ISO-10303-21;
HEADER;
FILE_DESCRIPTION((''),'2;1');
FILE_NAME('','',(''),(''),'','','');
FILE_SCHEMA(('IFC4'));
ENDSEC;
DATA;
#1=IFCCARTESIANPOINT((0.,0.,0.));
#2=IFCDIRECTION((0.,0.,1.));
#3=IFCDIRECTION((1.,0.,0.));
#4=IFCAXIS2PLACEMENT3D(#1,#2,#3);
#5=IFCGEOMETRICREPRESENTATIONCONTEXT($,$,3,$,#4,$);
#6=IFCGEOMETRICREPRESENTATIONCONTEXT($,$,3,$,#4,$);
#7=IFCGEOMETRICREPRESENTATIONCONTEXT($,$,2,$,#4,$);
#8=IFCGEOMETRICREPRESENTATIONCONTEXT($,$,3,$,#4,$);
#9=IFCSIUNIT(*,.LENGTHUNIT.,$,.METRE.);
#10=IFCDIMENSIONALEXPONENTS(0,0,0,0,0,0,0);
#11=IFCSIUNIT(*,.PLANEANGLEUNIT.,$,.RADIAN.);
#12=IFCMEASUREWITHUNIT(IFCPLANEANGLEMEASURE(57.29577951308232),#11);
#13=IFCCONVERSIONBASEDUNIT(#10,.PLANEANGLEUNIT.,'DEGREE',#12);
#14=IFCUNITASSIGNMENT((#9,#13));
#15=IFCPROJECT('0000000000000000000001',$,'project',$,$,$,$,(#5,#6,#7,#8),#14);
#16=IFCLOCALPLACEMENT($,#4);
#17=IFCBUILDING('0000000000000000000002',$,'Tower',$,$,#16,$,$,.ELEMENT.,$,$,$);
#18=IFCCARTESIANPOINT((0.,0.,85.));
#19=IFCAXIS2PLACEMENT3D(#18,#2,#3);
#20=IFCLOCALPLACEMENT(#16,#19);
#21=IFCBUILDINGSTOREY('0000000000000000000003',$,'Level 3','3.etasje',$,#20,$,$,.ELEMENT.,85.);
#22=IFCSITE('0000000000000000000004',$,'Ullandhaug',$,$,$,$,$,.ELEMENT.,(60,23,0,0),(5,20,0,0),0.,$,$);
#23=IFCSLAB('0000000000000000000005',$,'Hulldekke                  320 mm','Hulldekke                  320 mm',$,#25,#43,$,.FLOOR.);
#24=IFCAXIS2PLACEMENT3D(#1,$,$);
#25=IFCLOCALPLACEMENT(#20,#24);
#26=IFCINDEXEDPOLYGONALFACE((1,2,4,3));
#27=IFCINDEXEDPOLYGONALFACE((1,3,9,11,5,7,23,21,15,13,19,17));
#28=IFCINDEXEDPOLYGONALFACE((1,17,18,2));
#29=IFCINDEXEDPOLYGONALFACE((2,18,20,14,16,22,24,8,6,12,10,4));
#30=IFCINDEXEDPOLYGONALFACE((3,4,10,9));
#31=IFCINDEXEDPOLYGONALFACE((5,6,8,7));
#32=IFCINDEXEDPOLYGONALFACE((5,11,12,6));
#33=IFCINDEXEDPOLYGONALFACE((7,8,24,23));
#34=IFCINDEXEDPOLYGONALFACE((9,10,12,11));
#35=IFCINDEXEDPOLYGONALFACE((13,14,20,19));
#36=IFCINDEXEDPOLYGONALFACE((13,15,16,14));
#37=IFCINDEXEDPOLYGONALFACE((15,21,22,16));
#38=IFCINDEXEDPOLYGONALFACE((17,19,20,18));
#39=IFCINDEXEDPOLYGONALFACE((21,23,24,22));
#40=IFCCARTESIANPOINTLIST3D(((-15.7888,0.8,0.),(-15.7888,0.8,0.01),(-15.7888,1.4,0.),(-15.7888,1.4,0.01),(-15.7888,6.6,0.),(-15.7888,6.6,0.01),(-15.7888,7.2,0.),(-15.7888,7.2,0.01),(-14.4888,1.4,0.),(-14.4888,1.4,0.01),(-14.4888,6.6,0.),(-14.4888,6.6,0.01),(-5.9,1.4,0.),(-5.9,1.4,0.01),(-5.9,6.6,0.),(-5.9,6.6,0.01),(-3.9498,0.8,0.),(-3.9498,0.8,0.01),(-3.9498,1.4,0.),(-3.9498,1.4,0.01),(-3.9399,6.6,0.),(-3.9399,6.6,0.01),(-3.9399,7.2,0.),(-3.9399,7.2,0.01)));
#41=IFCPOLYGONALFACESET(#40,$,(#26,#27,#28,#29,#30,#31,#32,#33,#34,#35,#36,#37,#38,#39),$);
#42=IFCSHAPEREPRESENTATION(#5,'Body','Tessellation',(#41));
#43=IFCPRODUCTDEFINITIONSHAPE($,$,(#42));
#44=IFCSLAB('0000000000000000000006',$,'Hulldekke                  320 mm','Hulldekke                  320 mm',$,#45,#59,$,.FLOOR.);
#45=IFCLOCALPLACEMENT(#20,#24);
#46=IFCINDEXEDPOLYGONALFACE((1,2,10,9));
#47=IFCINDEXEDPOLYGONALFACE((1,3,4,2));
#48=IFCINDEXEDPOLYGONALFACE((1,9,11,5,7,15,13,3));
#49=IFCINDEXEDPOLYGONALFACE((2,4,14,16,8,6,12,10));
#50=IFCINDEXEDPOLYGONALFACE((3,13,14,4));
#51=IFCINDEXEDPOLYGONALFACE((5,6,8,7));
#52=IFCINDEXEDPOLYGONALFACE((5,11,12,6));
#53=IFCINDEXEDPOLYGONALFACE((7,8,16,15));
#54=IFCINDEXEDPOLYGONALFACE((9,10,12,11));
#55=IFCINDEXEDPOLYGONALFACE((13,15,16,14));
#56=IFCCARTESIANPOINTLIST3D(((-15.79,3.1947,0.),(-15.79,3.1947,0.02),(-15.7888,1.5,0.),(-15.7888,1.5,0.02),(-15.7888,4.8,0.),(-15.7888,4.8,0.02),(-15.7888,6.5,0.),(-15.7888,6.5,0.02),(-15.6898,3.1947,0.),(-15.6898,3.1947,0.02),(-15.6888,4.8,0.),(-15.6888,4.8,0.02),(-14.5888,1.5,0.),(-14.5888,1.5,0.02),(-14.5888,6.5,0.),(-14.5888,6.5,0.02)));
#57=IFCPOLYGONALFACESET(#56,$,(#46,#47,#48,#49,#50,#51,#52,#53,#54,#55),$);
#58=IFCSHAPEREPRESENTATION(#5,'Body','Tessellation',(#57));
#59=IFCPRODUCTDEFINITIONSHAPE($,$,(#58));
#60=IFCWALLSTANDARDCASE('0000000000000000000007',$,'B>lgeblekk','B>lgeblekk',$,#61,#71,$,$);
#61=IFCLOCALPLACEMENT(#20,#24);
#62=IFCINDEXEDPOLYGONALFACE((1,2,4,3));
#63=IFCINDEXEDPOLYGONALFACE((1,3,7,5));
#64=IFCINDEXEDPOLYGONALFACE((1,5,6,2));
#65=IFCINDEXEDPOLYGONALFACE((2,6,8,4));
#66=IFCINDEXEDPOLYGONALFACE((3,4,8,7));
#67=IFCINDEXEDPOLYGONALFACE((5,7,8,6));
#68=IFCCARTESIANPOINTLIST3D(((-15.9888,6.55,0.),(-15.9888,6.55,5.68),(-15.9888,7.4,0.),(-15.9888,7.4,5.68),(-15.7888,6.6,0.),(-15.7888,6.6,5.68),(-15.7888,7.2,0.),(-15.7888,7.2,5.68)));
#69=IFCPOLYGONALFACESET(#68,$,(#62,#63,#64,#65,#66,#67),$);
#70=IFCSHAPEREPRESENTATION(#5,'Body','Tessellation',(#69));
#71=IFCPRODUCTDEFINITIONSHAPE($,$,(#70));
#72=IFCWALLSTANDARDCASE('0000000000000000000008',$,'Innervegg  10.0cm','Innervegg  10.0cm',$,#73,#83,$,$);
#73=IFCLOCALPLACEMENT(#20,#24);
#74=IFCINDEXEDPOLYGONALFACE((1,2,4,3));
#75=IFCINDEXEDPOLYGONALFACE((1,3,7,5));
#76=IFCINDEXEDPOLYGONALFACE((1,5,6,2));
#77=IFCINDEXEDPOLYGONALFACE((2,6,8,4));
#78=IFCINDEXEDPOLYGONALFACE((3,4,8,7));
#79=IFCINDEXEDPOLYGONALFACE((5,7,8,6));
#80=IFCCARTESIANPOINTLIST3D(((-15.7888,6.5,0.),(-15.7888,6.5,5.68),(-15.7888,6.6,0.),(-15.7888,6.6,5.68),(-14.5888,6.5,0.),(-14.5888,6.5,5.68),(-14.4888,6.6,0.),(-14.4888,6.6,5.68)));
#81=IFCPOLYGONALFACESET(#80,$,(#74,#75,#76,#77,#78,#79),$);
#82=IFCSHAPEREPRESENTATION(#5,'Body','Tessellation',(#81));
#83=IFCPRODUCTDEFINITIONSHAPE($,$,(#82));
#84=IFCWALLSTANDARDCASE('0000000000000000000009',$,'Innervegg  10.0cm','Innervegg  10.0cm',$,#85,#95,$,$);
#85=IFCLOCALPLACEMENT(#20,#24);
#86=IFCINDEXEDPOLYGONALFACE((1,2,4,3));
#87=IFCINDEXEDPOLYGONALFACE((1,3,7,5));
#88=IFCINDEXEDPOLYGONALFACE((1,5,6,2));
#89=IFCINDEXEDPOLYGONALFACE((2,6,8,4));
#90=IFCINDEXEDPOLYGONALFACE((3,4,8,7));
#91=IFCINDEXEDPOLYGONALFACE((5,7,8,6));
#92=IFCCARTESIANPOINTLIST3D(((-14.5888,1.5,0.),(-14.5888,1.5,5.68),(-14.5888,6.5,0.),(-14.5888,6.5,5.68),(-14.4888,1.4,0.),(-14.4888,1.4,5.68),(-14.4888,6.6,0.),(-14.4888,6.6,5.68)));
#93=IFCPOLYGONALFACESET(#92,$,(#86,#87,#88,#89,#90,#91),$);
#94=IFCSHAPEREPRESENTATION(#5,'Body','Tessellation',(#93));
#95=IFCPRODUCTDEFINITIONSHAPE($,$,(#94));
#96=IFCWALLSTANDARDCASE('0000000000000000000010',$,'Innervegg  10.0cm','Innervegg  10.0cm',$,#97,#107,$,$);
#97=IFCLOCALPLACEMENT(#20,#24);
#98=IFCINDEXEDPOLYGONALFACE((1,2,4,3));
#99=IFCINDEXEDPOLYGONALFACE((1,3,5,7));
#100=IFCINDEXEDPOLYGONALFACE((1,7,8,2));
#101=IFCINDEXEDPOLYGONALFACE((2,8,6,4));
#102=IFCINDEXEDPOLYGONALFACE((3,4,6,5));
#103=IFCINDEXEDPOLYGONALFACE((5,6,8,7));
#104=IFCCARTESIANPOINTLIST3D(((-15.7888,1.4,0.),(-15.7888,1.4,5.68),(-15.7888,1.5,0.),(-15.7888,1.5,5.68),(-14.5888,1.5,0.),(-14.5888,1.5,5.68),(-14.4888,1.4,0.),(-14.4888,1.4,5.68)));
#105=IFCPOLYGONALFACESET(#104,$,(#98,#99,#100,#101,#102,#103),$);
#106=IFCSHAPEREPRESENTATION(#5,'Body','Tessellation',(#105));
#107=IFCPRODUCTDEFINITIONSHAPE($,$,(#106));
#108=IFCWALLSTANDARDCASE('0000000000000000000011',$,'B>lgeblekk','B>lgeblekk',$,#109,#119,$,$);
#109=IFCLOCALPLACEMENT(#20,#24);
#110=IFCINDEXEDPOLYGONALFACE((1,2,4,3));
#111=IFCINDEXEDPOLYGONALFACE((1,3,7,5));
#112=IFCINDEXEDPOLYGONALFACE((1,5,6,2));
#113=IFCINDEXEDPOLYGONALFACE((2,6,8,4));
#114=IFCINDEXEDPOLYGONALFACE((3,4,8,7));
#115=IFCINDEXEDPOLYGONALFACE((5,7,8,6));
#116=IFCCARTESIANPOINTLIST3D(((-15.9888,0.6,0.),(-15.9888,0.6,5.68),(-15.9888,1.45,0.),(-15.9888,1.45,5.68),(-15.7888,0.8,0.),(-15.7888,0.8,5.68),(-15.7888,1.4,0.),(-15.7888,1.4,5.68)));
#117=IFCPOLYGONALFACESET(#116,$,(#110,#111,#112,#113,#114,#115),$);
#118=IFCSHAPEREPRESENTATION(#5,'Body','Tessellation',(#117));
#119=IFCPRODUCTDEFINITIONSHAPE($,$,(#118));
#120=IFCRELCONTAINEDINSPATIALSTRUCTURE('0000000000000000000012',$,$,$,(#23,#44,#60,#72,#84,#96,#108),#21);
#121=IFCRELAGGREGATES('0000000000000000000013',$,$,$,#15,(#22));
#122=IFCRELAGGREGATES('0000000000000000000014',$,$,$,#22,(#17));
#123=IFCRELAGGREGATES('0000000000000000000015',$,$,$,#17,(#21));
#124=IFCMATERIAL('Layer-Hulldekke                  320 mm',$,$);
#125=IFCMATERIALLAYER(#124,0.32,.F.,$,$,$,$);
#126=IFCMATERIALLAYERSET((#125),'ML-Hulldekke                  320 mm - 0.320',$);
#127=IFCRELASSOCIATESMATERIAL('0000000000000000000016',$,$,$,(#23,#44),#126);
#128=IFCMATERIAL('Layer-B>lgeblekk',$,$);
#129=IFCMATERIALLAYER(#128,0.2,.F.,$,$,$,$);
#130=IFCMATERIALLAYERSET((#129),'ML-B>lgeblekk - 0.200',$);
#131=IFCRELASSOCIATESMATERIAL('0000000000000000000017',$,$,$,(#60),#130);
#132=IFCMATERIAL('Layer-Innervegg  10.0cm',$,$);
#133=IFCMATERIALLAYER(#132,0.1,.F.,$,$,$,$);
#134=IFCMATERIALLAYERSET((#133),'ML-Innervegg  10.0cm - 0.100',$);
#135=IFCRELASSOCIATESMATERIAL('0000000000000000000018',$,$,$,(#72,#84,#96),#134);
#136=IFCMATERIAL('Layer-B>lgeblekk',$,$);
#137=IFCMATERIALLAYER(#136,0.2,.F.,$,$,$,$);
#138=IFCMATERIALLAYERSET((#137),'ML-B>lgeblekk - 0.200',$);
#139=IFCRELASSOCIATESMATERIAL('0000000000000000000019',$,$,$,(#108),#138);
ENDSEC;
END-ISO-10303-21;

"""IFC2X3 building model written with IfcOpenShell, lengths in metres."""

from ifc_helpers import new_model, entity, si_unit, converted_unit, frame, origin_with_axes, place, context, project, spatial, polyline, outline, extrude, material, layer, layer_set, layer_usage, element, save


model = new_model("IFC2X3")

# Units and contexts
context_of_model_1 = context(None, 3, world=origin_with_axes())
context_of_model_2 = context(None, 3, world=origin_with_axes())
context_of_model_3 = context(None, 2, world=origin_with_axes())
context_of_model_4 = context(None, 3, world=origin_with_axes())
ifc_project = project(units=[si_unit("LENGTHUNIT", "METRE"), converted_unit("PLANEANGLEUNIT", "DEGREE", entity("IfcPlaneAngleMeasure", 57.29577951308232), si_unit("PLANEANGLEUNIT", "RADIAN"), dimensions=[0, 0, 0, 0, 0, 0, 0])], contexts=[context_of_model_1, context_of_model_2, context_of_model_3, context_of_model_4])

# Site, building, storey
site = spatial("IfcSite", under=ifc_project, Name="Ullandhaug", CompositionType="ELEMENT", RefLatitude=(60, 23, 0, 0), RefLongitude=(5, 20, 0, 0), RefElevation=0.0)
building_placement = place(None, origin_with_axes())
building = spatial("IfcBuilding", under=site, at=building_placement, Name="Tower", CompositionType="ELEMENT")
storey_placement = place(building_placement, frame((0.0, 0.0, 85.0), z_axis=(0.0, 0.0, 1.0), x_axis=(1.0, 0.0, 0.0)))
storey = spatial("IfcBuildingStorey", under=building, at=storey_placement, Name="Level 3", Description="3.etasje", CompositionType="ELEMENT", Elevation=85.0)

# Slabs
ifc_material_1 = material(Name="Layer-Hulldekke                  320 mm")
ifc_layer_1 = layer(ifc_material_1, 0.32, ventilated=False)
ifc_layer_set_1 = layer_set([ifc_layer_1], Name="ML-Hulldekke                  320 mm - 0.320")
ifc_layer_usage_1 = layer_usage(ifc_layer_set_1, "AXIS2", "POSITIVE", 0.0)
slab_1_placement = place(storey_placement, frame((-3.9399, 6.6, 0.0), z_axis=(0.0, 0.0, 1.0), x_axis=(1.0, 0.0, 0.0)))
element("IfcSlab", 1, at=slab_1_placement, inside=storey, material=ifc_layer_usage_1, Name="Hulldekke                  320 mm", Description="Hulldekke                  320 mm", PredefinedType="FLOOR", context=context_of_model_1, shape_type="SweptSolid", body=[
    extrude(outline(polyline([(0.0, 0.0), (0.6, 0.0), (0.6, 11.8489), (0.0, 11.8489), (0.0, 10.5489), (-5.2, 10.5489), (-5.2, 11.8489), (-5.8, 11.8489), (-5.8, 0.0099), (-5.2, 0.0099), (-5.2, 1.9601), (0.0, 1.9601), (0.0, 0.0)])), frame((0.0, 0.0, 0.0), z_axis=(0.0, 0.0, 1.0), x_axis=(0.0, 1.0, 0.0)), (0.0, 0.0, 1.0), 0.01),
])
slab_2_placement = place(storey_placement, frame((-15.7888, 6.5, 0.0), z_axis=(0.0, 0.0, 1.0), x_axis=(1.0, 0.0, 0.0)))
element("IfcSlab", 2, at=slab_2_placement, inside=storey, material=ifc_layer_usage_1, Name="Hulldekke                  320 mm", Description="Hulldekke                  320 mm", PredefinedType="FLOOR", context=context_of_model_1, shape_type="SweptSolid", body=[
    extrude(outline(polyline([(0.0, 0.0), (1.7, 0.0), (1.7, 0.1), (3.3053, 0.099), (3.3053, -0.0011), (5.0, 0.0), (5.0, 1.2), (0.0, 1.2), (0.0, 0.0)])), frame((0.0, 0.0, 0.0), z_axis=(0.0, 0.0, 1.0), x_axis=(0.0, -1.0, 0.0)), (0.0, 0.0, 1.0), 0.02),
])

# Walls
ifc_material_2 = material(Name="Layer-B>lgeblekk")
ifc_layer_2 = layer(ifc_material_2, 0.2, ventilated=False)
ifc_layer_set_2 = layer_set([ifc_layer_2], Name="ML-B>lgeblekk - 0.200")
ifc_layer_usage_2 = layer_usage(ifc_layer_set_2, "AXIS2", "POSITIVE", 0.0)
wall_1_placement = place(storey_placement, frame((-15.9888, 7.4, 0.0), z_axis=(0.0, 0.0, 1.0), x_axis=(0.0, -1.0, 0.0)))
element("IfcWallStandardCase", 3, at=wall_1_placement, inside=storey, material=ifc_layer_usage_2, Name="B>lgeblekk", Description="B>lgeblekk", context=context_of_model_1, shape_type="SweptSolid", body=[
    extrude(outline(polyline([(0.0, 0.0), (0.85, 0.0), (0.8, 0.2), (0.2, 0.2), (0.0, 0.0)])), frame((0.0, 0.0, 0.0), z_axis=(0.0, 0.0, 1.0), x_axis=(1.0, 0.0, 0.0)), (0.0, 0.0, 1.0), 5.68),
])
ifc_material_3 = material(Name="Layer-Innervegg  10.0cm")
ifc_layer_3 = layer(ifc_material_3, 0.1, ventilated=False)
ifc_layer_set_3 = layer_set([ifc_layer_3], Name="ML-Innervegg  10.0cm - 0.100")
ifc_layer_usage_3 = layer_usage(ifc_layer_set_3, "AXIS2", "POSITIVE", 0.0)
wall_2_placement = place(storey_placement, frame((-15.7888, 6.5, 0.0), z_axis=(0.0, 0.0, 1.0), x_axis=(1.0, 0.0, 0.0)))
element("IfcWallStandardCase", 4, at=wall_2_placement, inside=storey, material=ifc_layer_usage_3, Name="Innervegg  10.0cm", Description="Innervegg  10.0cm", context=context_of_model_1, shape_type="SweptSolid", body=[
    extrude(outline(polyline([(0.0, 0.0), (1.2, 0.0), (1.3, 0.1), (0.0, 0.1), (0.0, 0.0)])), origin_with_axes(), (0.0, 0.0, 1.0), 5.68),
])
wall_3_placement = place(storey_placement, frame((-14.5888, 6.5, 0.0), z_axis=(0.0, 0.0, 1.0), x_axis=(0.0, -1.0, 0.0)))
element("IfcWallStandardCase", 5, at=wall_3_placement, inside=storey, material=ifc_layer_usage_3, Name="Innervegg  10.0cm", Description="Innervegg  10.0cm", context=context_of_model_1, shape_type="SweptSolid", body=[
    extrude(outline(polyline([(0.0, 0.0), (5.0, 0.0), (5.1, 0.1), (-0.1, 0.1), (0.0, 0.0)])), frame((0.0, 0.0, 0.0), z_axis=(0.0, 0.0, 1.0), x_axis=(1.0, 0.0, 0.0)), (0.0, 0.0, 1.0), 5.68),
])
wall_4_placement = place(storey_placement, frame((-14.5888, 1.5, 0.0), z_axis=(0.0, 0.0, 1.0), x_axis=(-1.0, 0.0, 0.0)))
element("IfcWallStandardCase", 6, at=wall_4_placement, inside=storey, material=ifc_layer_usage_3, Name="Innervegg  10.0cm", Description="Innervegg  10.0cm", context=context_of_model_1, shape_type="SweptSolid", body=[
    extrude(outline(polyline([(0.0, 0.0), (1.2, 0.0), (1.2, 0.1), (-0.1, 0.1), (0.0, 0.0)])), frame((0.0, 0.0, 0.0), z_axis=(0.0, 0.0, 1.0), x_axis=(1.0, 0.0, 0.0)), (0.0, 0.0, 1.0), 5.68),
])
ifc_material_4 = material(Name="Layer-B>lgeblekk")
ifc_layer_4 = layer(ifc_material_4, 0.2, ventilated=False)
ifc_layer_set_4 = layer_set([ifc_layer_4], Name="ML-B>lgeblekk - 0.200")
ifc_layer_usage_4 = layer_usage(ifc_layer_set_4, "AXIS2", "POSITIVE", 0.0)
wall_5_placement = place(storey_placement, frame((-15.9888, 1.45, 0.0), z_axis=(0.0, 0.0, 1.0), x_axis=(0.0, -1.0, 0.0)))
element("IfcWallStandardCase", 7, at=wall_5_placement, inside=storey, material=ifc_layer_usage_4, Name="B>lgeblekk", Description="B>lgeblekk", context=context_of_model_1, shape_type="SweptSolid", body=[
    extrude(outline(polyline([(0.0, 0.0), (0.85, 0.0), (0.65, 0.2), (0.05, 0.2), (0.0, 0.0)])), frame((0.0, 0.0, 0.0), z_axis=(0.0, 0.0, 1.0), x_axis=(1.0, 0.0, 0.0)), (0.0, 0.0, 1.0), 5.68),
])

save(model, "model.ifc")
